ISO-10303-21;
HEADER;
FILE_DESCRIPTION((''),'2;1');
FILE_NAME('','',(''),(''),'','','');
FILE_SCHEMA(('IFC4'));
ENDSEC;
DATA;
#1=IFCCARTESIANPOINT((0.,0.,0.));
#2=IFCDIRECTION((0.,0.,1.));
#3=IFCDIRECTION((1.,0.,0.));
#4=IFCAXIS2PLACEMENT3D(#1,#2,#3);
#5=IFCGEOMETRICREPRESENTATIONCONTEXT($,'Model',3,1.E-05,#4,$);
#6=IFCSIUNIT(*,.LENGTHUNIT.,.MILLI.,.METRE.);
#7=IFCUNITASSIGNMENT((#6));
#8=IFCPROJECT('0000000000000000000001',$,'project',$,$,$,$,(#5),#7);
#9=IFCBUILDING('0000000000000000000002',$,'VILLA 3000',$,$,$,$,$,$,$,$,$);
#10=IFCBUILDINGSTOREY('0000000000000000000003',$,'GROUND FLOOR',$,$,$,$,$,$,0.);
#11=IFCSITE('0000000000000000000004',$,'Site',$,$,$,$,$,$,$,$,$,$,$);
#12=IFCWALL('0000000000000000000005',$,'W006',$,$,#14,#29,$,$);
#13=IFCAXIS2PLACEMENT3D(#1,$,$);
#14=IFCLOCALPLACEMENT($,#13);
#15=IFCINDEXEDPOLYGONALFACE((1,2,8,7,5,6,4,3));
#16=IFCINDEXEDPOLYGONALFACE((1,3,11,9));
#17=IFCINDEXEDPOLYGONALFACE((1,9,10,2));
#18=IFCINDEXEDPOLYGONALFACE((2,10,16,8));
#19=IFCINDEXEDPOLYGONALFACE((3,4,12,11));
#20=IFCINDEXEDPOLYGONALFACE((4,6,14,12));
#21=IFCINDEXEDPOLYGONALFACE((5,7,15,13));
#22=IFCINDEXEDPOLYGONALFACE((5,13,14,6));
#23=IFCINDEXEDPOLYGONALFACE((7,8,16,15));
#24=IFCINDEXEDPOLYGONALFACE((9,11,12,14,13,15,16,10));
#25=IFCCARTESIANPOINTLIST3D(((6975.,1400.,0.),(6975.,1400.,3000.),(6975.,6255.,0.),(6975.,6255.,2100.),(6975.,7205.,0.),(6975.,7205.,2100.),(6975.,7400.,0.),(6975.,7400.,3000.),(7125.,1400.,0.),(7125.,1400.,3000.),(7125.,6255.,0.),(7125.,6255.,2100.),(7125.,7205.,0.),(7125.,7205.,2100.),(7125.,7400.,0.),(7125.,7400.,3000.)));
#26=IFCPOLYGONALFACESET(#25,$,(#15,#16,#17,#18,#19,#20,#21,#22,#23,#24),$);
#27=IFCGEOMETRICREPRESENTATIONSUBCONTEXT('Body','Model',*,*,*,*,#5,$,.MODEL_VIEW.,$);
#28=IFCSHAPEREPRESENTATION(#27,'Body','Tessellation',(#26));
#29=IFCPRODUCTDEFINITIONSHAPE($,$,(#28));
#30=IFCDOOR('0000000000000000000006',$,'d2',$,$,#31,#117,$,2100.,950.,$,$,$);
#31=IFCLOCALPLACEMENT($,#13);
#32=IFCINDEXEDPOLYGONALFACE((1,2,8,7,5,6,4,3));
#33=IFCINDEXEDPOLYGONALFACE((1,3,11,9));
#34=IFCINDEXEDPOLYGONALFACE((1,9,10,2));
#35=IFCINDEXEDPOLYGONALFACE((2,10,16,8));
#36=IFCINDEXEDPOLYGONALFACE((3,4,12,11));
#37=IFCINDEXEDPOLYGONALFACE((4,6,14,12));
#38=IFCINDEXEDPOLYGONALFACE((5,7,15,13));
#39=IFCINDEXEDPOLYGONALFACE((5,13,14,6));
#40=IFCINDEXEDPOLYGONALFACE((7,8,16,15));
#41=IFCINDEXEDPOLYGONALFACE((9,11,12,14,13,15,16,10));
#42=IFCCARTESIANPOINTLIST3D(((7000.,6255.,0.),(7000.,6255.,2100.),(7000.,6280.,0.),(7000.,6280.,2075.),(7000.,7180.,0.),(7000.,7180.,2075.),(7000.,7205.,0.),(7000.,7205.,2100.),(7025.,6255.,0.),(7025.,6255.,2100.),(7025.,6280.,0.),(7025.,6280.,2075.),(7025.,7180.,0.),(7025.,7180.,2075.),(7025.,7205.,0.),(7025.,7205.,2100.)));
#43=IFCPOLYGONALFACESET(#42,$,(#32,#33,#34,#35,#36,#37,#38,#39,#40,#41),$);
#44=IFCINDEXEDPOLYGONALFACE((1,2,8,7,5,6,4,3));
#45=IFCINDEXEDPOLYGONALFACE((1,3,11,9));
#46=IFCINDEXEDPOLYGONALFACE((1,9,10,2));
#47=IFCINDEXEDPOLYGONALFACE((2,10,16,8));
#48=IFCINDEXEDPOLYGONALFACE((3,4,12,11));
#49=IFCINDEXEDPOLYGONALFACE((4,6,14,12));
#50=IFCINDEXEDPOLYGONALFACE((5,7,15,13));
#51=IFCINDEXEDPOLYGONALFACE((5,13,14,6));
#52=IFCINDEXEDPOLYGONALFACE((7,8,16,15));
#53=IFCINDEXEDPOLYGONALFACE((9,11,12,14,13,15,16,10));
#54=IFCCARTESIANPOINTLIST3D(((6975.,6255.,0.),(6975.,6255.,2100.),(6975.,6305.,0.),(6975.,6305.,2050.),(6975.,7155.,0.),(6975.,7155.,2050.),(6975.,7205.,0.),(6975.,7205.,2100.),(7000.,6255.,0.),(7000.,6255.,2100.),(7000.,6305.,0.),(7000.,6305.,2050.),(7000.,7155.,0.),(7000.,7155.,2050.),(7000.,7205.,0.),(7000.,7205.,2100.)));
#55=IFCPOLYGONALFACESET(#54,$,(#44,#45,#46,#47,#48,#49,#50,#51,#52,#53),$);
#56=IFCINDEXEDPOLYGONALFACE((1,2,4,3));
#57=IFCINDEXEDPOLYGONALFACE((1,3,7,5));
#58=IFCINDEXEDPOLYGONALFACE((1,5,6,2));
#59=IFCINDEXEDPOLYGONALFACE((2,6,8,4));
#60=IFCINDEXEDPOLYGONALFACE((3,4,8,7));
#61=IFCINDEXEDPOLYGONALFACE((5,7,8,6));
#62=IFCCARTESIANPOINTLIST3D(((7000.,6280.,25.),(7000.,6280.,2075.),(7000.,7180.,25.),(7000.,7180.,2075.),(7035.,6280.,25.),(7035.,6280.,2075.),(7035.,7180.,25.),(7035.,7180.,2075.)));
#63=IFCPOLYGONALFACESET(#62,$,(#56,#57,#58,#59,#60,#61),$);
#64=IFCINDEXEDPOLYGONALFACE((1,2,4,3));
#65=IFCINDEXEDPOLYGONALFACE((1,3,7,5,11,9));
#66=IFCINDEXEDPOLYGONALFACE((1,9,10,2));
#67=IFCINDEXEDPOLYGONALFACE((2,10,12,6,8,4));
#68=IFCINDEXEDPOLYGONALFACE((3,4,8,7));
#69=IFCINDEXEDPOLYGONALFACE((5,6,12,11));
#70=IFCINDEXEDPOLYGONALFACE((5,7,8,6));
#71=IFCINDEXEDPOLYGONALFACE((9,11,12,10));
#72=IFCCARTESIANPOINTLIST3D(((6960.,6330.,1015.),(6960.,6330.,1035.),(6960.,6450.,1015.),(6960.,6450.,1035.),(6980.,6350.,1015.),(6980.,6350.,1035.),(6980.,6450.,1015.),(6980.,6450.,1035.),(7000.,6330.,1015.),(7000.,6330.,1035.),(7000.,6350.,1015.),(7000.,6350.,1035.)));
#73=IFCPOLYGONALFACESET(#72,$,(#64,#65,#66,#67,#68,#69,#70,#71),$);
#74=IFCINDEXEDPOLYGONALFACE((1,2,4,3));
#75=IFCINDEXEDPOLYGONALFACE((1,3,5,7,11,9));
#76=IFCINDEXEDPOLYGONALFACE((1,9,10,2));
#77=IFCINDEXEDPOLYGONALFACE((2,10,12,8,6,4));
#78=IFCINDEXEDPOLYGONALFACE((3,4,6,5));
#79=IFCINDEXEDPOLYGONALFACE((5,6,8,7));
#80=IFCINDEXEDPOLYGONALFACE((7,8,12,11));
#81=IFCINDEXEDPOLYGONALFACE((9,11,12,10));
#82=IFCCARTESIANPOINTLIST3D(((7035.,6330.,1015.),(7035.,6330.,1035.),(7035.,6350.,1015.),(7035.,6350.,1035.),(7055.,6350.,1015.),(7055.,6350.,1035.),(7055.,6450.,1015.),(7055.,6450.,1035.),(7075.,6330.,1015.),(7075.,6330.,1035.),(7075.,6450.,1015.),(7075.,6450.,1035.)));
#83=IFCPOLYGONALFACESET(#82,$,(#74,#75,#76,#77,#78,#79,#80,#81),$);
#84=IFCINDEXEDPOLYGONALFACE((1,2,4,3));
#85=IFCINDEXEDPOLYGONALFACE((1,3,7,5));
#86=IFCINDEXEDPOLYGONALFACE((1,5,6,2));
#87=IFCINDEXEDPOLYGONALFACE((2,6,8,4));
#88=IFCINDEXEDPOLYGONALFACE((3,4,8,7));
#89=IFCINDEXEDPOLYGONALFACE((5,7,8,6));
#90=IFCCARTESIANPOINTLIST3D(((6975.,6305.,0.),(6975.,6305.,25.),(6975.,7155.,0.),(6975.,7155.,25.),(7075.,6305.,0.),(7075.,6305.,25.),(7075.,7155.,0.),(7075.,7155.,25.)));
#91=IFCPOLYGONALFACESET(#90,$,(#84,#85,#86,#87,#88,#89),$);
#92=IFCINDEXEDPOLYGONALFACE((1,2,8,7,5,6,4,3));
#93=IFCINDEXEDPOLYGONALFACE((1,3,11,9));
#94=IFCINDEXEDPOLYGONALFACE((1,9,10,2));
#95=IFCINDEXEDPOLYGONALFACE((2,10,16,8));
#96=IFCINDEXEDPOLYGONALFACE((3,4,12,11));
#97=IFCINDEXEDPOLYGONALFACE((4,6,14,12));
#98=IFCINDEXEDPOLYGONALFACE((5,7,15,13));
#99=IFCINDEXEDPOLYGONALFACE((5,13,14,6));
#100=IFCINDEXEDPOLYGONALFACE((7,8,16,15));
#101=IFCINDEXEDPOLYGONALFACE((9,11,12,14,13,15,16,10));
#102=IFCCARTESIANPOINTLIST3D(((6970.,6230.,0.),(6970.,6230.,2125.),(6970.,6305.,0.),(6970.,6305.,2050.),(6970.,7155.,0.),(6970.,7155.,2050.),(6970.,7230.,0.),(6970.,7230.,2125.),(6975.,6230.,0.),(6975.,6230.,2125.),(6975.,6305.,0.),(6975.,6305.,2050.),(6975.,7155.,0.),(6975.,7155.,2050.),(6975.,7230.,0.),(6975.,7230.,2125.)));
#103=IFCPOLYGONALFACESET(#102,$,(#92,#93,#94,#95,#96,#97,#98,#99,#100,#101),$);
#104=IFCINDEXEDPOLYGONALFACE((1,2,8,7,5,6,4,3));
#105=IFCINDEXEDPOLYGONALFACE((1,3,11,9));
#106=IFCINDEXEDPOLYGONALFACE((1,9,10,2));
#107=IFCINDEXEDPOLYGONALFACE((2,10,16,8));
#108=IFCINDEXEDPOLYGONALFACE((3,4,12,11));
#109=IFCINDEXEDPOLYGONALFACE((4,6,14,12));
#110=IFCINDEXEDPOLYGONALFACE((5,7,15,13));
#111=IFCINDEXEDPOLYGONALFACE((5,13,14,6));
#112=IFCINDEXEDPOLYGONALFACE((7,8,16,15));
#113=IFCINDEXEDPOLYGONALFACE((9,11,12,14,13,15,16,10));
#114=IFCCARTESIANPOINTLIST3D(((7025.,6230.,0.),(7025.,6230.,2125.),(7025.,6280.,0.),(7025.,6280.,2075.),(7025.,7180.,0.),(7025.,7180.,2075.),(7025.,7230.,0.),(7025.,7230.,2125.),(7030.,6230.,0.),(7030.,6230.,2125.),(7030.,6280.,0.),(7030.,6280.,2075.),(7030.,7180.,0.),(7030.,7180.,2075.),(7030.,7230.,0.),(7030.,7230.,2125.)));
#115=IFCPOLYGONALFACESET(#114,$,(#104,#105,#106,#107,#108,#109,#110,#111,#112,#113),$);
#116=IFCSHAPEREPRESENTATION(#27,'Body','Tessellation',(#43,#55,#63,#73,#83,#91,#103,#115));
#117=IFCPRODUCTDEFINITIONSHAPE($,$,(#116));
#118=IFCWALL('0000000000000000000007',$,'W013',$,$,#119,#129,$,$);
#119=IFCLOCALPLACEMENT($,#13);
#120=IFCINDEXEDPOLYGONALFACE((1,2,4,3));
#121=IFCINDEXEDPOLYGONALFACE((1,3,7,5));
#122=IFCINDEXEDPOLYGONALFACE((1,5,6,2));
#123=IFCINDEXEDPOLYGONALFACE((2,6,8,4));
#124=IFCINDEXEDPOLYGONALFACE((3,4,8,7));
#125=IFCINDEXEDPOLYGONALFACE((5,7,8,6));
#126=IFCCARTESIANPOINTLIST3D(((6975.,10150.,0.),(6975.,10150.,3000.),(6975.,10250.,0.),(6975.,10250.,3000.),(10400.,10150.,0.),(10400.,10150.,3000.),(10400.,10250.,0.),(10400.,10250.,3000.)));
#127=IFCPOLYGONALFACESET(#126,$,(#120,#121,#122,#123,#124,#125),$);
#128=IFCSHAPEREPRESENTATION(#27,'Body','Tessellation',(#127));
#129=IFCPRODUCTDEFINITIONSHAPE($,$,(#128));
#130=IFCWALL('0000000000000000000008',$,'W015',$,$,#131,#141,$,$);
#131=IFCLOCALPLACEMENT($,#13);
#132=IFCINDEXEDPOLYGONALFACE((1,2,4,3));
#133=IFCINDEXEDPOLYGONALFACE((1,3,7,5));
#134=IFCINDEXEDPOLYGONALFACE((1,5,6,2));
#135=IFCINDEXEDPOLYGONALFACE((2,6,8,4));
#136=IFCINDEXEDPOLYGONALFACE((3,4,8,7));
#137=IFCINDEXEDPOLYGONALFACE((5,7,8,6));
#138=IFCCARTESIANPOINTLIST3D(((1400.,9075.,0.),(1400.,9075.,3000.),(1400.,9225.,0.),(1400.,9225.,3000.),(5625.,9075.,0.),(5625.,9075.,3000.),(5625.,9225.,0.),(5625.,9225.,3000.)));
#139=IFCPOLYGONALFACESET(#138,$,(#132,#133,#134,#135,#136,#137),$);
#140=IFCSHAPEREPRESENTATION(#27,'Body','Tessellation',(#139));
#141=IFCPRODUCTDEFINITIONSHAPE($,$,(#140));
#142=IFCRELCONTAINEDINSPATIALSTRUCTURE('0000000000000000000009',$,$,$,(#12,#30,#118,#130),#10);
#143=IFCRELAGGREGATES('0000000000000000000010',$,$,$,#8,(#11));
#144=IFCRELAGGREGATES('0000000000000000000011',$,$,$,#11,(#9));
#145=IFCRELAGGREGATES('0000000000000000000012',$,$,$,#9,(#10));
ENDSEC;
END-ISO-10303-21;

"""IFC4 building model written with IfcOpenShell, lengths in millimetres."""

from ifc_helpers import new_model, si_unit, frame, origin_with_axes, place, context, subcontext, project, spatial, line, indexed_curve, outline, extrude, element, fill, save


model = new_model("IFC4")

# Units and contexts
model_context = context("Model", 3, precision=1e-05, world=origin_with_axes())
body_context = subcontext(model_context, "Body", "Model", "MODEL_VIEW")
ifc_project = project(units=[si_unit("LENGTHUNIT", "METRE", prefix="MILLI")], contexts=[model_context])

# Site, building, storey
site = spatial("IfcSite", under=ifc_project, Name="Site")
building = spatial("IfcBuilding", under=site, Name="VILLA 3000")
storey = spatial("IfcBuildingStorey", under=building, Name="GROUND FLOOR", Elevation=0.0)

# Wall, opening, door
wall_1_placement = place(None, frame((7050.0, 7400.0, 0.0), z_axis=(0.0, 0.0, 1.0), x_axis=(0.0, -1.0, 0.0)))
wall_1 = element("IfcWall", 1, at=wall_1_placement, inside=storey, Name="W006", context=body_context, shape_type="SweptSolid", body=[
    extrude(outline(indexed_curve([(0.0, 0.0), (0.0, 150.0), (6000.0, 150.0), (6000.0, 0.0), (0.0, 0.0)], self_intersect=False)), frame((0.0, -75.0, 0.0), z_axis=(0.0, 0.0, 1.0), x_axis=(1.0, 0.0, 0.0)), (0.0, 0.0, 1.0), 3000.0),
])
opening_1_placement = place(wall_1_placement, frame((195.0, 0.0, 0.0), z_axis=(0.0, 0.0, 1.0), x_axis=(1.0, 0.0, 0.0)))
opening_1 = element("IfcOpeningElement", 2, at=opening_1_placement, cuts=wall_1, context=body_context, shape_type="SweptSolid", body=[
    extrude(outline(indexed_curve([(0.0, 0.0), (0.0, 250.0), (950.0, 250.0), (950.0, 0.0), (0.0, 0.0)], self_intersect=False)), frame((0.0, -125.0, 0.0), z_axis=(0.0, 0.0, 1.0), x_axis=(1.0, 0.0, 0.0)), (0.0, 0.0, 1.0), 2100.0),
])
door_1_placement = place(None, frame((6975.0, 7205.0, 0.0), z_axis=(0.0, 0.0, 1.0), x_axis=(0.0, -1.0, 0.0)))
door_1 = element("IfcDoor", 3, at=door_1_placement, inside=storey, Name="d2", OverallHeight=2100.0, OverallWidth=950.0, context=body_context, shape_type="SweptSolid", body=[
    extrude(outline(indexed_curve([(0.0, 0.0), (0.0, 2100.0), (950.0, 2100.0), (950.0, 0.0), (925.0, 0.0), (925.0, 2075.0), (25.0, 2075.0), (25.0, 0.0)], segments=[line(1, 2, 3, 4, 5, 6, 7, 8, 1)])), frame((0.0, 25.0, 0.0), z_axis=(0.0, -1.0, 0.0), x_axis=(1.0, 0.0, 0.0)), (0.0, 0.0, -1.0), 25.0),
    extrude(outline(indexed_curve([(0.0, 0.0), (0.0, 2100.0), (950.0, 2100.0), (950.0, 0.0), (900.0, 0.0), (900.0, 2050.0), (50.0, 2050.0), (50.0, 0.0)], segments=[line(1, 2, 3, 4, 5, 6, 7, 8, 1)])), frame((0.0, 0.0, 0.0), z_axis=(0.0, -1.0, 0.0), x_axis=(1.0, 0.0, 0.0)), (0.0, 0.0, -1.0), 25.0),
    extrude(outline(indexed_curve([(0.0, 0.0), (900.0, 0.0), (900.0, 35.0), (0.0, 35.0)], segments=[line(1, 2, 3, 4, 1)])), frame((25.0, 25.0, 25.0), z_axis=(0.0, 0.0, 1.0), x_axis=(1.0, 0.0, 0.0)), (0.0, 0.0, 1.0), 2050.0),
    extrude(outline(indexed_curve([(0.0, 0.0), (0.0, -40.0), (-120.0, -40.0), (-120.0, -20.0), (-20.0, -20.0), (-20.0, 0.0)], segments=[line(1, 2, 3, 4, 5, 6, 1)])), frame((875.0, 25.0, 1015.0), z_axis=(0.0, 0.0, 1.0), x_axis=(1.0, 0.0, 0.0)), (0.0, 0.0, 1.0), 20.0),
    extrude(outline(indexed_curve([(0.0, 0.0), (0.0, 40.0), (-120.0, 40.0), (-120.0, 20.0), (-20.0, 20.0), (-20.0, 0.0)], segments=[line(1, 2, 3, 4, 5, 6, 1)])), frame((875.0, 60.0, 1015.0), z_axis=(0.0, 0.0, 1.0), x_axis=(1.0, 0.0, 0.0)), (0.0, 0.0, 1.0), 20.0),
    extrude(outline(indexed_curve([(0.0, 0.0), (850.0, 0.0), (850.0, 100.0), (0.0, 100.0)], segments=[line(1, 2, 3, 4, 1)])), frame((50.0, 0.0, 0.0), z_axis=(0.0, 0.0, 1.0), x_axis=(1.0, 0.0, 0.0)), (0.0, 0.0, 1.0), 25.0),
    extrude(outline(indexed_curve([(0.0, 0.0), (0.0, 2125.0), (1000.0, 2125.0), (1000.0, 0.0), (925.0, 0.0), (925.0, 2050.0), (75.0, 2050.0), (75.0, 0.0)], segments=[line(1, 2, 3, 4, 5, 6, 7, 8, 1)])), frame((-25.0, -5.0, 0.0), z_axis=(0.0, -1.0, 0.0), x_axis=(1.0, 0.0, 0.0)), (0.0, 0.0, -1.0), 5.0),
    extrude(outline(indexed_curve([(0.0, 0.0), (0.0, 2125.0), (1000.0, 2125.0), (1000.0, 0.0), (950.0, 0.0), (950.0, 2075.0), (50.0, 2075.0), (50.0, 0.0)], segments=[line(1, 2, 3, 4, 5, 6, 7, 8, 1)])), frame((-25.0, 50.0, 0.0), z_axis=(0.0, -1.0, 0.0), x_axis=(1.0, 0.0, 0.0)), (0.0, 0.0, -1.0), 5.0),
])
fill(opening_1, door_1)

# Walls
wall_2_placement = place(None, frame((6975.0, 10200.0, 0.0), z_axis=(0.0, 0.0, 1.0), x_axis=(1.0, 0.0, 0.0)))
element("IfcWall", 4, at=wall_2_placement, inside=storey, Name="W013", context=body_context, shape_type="SweptSolid", body=[
    extrude(outline(indexed_curve([(0.0, 0.0), (0.0, 100.0), (3425.0, 100.0), (3425.0, 0.0), (0.0, 0.0)], self_intersect=False)), frame((0.0, -50.0, 0.0), z_axis=(0.0, 0.0, 1.0), x_axis=(1.0, 0.0, 0.0)), (0.0, 0.0, 1.0), 3000.0),
])
wall_3_placement = place(None, frame((1400.0, 9150.0, 0.0), z_axis=(0.0, 0.0, 1.0), x_axis=(1.0, 0.0, 0.0)))
element("IfcWall", 5, at=wall_3_placement, inside=storey, Name="W015", context=body_context, shape_type="SweptSolid", body=[
    extrude(outline(indexed_curve([(0.0, 0.0), (0.0, 150.0), (4225.0, 150.0), (4225.0, 0.0), (0.0, 0.0)], self_intersect=False)), frame((0.0, -75.0, 0.0), z_axis=(0.0, 0.0, 1.0), x_axis=(1.0, 0.0, 0.0)), (0.0, 0.0, 1.0), 3000.0),
])

save(model, "model.ifc")
